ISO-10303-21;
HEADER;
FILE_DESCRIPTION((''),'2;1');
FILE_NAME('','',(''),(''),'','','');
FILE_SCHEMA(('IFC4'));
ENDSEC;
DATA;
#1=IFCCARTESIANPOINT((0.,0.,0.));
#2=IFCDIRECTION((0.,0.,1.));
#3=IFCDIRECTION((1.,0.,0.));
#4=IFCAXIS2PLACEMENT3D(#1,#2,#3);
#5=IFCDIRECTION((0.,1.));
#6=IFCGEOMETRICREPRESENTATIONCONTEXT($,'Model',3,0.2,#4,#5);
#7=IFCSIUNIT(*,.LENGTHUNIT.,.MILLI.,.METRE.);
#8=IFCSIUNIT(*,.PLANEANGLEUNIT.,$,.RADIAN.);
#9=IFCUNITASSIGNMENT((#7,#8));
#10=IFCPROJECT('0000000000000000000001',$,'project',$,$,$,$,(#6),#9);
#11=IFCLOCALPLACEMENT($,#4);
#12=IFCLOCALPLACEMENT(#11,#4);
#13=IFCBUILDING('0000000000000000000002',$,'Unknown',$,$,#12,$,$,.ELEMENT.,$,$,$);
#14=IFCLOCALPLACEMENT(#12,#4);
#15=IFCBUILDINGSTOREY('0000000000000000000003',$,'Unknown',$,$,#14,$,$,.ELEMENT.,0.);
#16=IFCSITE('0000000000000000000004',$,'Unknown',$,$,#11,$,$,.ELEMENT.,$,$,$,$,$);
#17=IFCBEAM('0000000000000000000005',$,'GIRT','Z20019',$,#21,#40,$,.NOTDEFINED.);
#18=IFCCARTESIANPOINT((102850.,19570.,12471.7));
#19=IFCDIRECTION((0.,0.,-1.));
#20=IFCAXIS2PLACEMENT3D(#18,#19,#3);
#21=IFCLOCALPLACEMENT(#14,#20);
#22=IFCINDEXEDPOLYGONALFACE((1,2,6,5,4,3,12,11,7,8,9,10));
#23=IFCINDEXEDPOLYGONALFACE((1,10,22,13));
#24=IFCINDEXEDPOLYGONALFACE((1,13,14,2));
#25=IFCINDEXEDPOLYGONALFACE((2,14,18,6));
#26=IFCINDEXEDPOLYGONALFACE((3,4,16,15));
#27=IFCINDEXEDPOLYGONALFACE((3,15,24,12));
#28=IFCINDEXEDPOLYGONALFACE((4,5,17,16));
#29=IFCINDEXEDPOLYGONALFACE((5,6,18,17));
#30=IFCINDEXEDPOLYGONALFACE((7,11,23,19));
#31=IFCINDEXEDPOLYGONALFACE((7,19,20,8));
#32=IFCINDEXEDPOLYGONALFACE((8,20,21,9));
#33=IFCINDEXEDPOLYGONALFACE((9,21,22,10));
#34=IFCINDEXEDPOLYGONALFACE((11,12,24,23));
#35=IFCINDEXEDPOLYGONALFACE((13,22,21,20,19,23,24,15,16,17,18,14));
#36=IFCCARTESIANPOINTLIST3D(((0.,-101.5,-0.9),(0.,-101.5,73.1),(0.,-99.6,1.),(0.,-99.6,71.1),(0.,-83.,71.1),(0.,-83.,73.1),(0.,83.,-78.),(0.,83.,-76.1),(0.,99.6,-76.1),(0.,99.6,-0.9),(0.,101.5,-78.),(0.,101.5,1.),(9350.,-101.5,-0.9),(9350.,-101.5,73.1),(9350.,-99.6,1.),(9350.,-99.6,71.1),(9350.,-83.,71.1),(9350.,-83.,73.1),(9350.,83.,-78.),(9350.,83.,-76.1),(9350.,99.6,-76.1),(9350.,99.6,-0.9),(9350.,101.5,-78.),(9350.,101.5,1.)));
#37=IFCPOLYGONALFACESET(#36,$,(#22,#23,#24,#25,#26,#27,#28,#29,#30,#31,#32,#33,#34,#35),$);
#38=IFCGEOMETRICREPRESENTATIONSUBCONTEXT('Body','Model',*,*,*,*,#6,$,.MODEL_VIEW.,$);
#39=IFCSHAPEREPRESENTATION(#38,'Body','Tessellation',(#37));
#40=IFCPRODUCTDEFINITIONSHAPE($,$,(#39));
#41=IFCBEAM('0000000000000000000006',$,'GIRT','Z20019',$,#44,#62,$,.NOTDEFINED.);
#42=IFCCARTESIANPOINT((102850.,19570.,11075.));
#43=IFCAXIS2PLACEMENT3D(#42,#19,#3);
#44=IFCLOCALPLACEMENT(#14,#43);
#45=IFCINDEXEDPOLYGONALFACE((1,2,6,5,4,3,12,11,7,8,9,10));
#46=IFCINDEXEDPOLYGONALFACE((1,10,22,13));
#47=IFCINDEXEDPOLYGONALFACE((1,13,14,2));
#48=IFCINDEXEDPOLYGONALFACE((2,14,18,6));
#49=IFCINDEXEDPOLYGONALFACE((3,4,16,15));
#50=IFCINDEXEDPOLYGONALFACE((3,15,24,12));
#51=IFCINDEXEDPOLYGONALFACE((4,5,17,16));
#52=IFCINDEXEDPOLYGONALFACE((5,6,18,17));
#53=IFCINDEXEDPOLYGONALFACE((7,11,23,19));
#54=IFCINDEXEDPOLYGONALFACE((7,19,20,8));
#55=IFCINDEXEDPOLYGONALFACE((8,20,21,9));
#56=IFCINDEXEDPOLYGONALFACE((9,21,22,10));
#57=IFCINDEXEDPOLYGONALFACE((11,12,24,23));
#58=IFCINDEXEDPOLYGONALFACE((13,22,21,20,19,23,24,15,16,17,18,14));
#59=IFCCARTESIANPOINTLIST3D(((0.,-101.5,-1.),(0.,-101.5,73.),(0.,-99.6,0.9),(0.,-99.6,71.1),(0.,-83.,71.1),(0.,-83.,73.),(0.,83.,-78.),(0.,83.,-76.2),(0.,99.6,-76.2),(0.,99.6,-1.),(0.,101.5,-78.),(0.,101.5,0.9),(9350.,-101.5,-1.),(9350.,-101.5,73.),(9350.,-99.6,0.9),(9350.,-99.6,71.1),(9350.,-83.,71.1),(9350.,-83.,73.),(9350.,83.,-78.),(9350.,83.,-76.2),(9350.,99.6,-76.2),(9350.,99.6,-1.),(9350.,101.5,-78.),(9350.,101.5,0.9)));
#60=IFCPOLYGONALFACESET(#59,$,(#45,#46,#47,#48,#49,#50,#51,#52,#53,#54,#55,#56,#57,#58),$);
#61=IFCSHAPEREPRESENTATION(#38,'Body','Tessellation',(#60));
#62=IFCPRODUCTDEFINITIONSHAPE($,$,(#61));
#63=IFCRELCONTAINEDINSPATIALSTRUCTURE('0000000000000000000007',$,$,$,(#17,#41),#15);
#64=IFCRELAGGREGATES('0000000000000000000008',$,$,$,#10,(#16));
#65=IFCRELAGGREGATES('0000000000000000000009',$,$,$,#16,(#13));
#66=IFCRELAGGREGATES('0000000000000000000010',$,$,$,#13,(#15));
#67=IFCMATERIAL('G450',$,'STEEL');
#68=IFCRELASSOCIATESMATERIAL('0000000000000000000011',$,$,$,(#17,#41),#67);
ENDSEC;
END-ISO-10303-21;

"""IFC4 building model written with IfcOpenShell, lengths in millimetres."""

from ifc_helpers import new_model, si_unit, direction, frame, origin_with_axes, place, context, subcontext, project, spatial, line, indexed_curve, outline, extrude, material, element, save


model = new_model("IFC4")

# Units and contexts
model_context = context("Model", 3, precision=0.2, world=origin_with_axes(), true_north=direction((0.0, 1.0)))
body_context = subcontext(model_context, "Body", "Model", "MODEL_VIEW")
ifc_project = project(units=[si_unit("LENGTHUNIT", "METRE", prefix="MILLI"), si_unit("PLANEANGLEUNIT", "RADIAN")], contexts=[model_context])

# Site, building, storey
site_placement = place(None, origin_with_axes())
site = spatial("IfcSite", under=ifc_project, at=site_placement, Name="Unknown", CompositionType="ELEMENT")
building_placement = place(site_placement, origin_with_axes())
building = spatial("IfcBuilding", under=site, at=building_placement, Name="Unknown", CompositionType="ELEMENT")
storey_placement = place(building_placement, origin_with_axes())
storey = spatial("IfcBuildingStorey", under=building, at=storey_placement, Name="Unknown", CompositionType="ELEMENT", Elevation=0.0)

# Beams
ifc_material_1 = material(Name="G450", Category="STEEL")
for number, where, z_axis, x_axis, name in (
    (1, (102850.0, 19570.0, 12471.7), (0.0, 0.0, -1.0), (1.0, 0.0, 0.0), "GIRT"),
    (2, (102850.0, 19570.0, 11075.0), (0.0, 0.0, -1.0), (1.0, 0.0, 0.0), "GIRT"),
):
    element("IfcBeam", number, at=place(storey_placement, frame(where, z_axis=z_axis, x_axis=x_axis)), inside=storey, material=ifc_material_1, Name=name, Description="Z20019", PredefinedType="NOTDEFINED", context=body_context, shape_type="SolidModel", body=[
        extrude(outline(indexed_curve([(73.0, -101.5), (73.0, -83.0), (71.2, -83.0), (71.2, -99.6), (0.9, -99.6), (0.9, 101.5), (-78.0, 101.5), (-78.0, 83.0), (-76.2, 83.0), (-76.2, 99.6), (-0.9, 99.6), (-0.9, -101.5)], segments=[line(1, 2, 3, 4, 5, 6, 7, 8, 9, 10, 11, 12, 1)])), frame((0.0, 0.0, 0.0), z_axis=(-1.0, 0.0, 0.0), x_axis=(0.0, 0.0, 1.0)), (0.0, 0.0, -1.0), 9350.0),
    ])

save(model, "model.ifc")
